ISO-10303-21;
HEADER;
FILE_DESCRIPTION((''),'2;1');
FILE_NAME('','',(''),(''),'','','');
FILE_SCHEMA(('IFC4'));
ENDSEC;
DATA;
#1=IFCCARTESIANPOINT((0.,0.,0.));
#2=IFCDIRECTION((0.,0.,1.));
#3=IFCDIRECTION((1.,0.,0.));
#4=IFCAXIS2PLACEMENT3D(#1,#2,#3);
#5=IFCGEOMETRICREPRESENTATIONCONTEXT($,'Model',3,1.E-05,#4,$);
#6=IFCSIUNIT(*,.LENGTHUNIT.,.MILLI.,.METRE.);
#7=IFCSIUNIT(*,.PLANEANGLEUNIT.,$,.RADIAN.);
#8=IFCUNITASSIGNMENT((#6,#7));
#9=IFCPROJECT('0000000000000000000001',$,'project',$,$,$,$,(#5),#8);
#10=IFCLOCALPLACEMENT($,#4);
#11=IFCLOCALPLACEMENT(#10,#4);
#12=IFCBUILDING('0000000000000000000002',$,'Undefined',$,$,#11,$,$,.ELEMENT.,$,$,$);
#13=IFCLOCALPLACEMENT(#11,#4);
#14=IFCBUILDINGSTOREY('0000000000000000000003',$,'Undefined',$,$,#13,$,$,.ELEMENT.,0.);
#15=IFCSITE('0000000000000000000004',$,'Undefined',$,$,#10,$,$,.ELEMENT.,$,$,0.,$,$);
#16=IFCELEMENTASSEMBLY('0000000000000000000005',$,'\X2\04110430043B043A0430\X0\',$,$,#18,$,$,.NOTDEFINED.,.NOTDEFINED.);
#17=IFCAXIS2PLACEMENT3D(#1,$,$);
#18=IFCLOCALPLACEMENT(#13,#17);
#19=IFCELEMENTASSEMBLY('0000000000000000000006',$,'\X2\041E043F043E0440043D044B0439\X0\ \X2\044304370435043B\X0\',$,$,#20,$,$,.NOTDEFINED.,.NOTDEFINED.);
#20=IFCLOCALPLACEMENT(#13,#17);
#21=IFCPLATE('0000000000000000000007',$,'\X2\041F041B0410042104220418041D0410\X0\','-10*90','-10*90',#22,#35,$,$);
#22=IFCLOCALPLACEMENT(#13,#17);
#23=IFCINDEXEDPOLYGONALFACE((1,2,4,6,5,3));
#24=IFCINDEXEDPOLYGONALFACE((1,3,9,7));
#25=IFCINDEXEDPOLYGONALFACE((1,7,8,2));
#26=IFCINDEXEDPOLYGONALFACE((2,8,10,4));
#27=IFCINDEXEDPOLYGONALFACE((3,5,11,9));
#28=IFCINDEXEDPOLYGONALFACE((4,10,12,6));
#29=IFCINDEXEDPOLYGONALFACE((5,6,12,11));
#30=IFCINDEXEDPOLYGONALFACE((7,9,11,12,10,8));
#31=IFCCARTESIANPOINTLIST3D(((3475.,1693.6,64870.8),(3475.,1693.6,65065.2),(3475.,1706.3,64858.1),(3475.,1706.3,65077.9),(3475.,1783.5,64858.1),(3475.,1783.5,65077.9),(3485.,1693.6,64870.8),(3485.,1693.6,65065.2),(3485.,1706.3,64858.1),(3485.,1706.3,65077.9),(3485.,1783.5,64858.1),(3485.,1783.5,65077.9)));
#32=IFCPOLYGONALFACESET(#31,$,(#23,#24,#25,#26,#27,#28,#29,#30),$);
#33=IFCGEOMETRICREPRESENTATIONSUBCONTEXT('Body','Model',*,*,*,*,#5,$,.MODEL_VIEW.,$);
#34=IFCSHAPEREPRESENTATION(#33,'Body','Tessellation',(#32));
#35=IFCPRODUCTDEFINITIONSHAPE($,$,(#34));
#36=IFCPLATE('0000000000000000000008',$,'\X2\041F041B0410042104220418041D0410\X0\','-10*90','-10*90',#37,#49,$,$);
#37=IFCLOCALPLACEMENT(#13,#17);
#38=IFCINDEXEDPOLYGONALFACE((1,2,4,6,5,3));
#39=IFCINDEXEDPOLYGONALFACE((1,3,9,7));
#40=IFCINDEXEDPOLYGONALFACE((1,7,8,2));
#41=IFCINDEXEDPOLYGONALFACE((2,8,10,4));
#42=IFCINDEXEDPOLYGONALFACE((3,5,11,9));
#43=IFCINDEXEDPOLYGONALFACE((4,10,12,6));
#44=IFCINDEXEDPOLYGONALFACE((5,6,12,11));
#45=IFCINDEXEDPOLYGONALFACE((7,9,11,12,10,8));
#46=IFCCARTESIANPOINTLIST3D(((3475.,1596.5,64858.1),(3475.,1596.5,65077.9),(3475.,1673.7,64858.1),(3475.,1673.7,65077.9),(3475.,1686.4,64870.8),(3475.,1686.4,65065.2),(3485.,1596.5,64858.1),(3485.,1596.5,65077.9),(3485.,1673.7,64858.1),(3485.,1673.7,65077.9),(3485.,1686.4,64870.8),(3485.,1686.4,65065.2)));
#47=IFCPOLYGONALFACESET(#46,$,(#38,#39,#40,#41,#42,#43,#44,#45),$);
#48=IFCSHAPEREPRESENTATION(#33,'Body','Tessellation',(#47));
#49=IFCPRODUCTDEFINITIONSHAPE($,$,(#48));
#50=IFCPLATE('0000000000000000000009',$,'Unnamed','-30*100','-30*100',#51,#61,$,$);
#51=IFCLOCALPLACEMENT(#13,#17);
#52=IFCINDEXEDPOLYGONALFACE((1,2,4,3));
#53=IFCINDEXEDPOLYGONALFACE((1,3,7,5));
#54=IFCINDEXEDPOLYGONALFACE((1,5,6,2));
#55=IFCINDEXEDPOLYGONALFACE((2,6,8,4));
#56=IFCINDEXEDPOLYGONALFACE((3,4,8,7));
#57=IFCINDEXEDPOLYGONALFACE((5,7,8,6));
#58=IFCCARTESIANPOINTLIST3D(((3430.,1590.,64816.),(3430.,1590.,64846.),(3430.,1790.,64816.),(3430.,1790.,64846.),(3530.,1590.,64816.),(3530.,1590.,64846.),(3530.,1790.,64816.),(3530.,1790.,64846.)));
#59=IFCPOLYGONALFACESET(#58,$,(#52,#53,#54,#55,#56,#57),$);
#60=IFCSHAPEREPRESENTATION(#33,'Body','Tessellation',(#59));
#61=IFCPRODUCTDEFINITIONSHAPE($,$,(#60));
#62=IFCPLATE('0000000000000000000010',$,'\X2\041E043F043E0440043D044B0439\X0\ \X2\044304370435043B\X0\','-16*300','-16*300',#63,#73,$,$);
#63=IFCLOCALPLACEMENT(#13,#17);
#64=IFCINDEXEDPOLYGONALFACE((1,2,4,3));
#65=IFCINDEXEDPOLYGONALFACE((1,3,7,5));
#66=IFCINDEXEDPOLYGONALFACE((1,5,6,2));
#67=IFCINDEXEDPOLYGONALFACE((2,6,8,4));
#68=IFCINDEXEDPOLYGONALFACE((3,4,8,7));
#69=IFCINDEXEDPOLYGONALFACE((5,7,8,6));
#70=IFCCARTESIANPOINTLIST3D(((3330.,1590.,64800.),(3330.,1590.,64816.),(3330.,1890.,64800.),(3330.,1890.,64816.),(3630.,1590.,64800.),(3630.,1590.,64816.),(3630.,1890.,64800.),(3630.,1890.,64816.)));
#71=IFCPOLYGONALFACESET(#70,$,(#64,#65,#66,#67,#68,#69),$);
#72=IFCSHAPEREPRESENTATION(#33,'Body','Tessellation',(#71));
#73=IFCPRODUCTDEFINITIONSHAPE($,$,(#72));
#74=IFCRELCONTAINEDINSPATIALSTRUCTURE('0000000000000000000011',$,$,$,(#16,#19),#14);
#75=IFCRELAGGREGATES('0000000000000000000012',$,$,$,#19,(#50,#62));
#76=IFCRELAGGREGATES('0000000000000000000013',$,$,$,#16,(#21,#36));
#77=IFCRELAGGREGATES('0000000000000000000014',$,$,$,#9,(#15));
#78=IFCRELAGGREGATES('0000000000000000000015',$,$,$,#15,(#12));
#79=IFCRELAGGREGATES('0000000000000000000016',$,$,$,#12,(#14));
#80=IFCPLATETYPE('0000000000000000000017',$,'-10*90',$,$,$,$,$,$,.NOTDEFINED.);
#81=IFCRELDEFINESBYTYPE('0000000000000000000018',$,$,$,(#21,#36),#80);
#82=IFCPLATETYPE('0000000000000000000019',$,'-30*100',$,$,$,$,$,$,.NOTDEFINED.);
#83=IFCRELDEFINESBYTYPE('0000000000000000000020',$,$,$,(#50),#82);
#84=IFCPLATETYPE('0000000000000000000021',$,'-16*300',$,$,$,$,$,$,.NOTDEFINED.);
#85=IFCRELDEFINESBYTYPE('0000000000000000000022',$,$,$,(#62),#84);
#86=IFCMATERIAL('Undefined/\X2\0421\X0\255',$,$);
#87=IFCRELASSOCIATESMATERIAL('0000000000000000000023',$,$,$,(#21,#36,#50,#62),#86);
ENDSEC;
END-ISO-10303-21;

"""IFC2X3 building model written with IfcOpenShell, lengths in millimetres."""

from ifc_helpers import new_model, si_unit, frame, origin_with_axes, place, context, subcontext, project, spatial, polyline, outline, extrude, material, type_object, element, aggregate, save


model = new_model("IFC2X3")

# Units and contexts
model_context = context("Model", 3, precision=1e-05, world=origin_with_axes())
body_context = subcontext(model_context, "Body", "Model", "MODEL_VIEW")
ifc_project = project(units=[si_unit("LENGTHUNIT", "METRE", prefix="MILLI"), si_unit("PLANEANGLEUNIT", "RADIAN")], contexts=[model_context])

# Site, building, storey
site_placement = place(None, origin_with_axes())
site = spatial("IfcSite", under=ifc_project, at=site_placement, Name="Undefined", CompositionType="ELEMENT", RefElevation=0.0)
building_placement = place(site_placement, origin_with_axes())
building = spatial("IfcBuilding", under=site, at=building_placement, Name="Undefined", CompositionType="ELEMENT")
storey_placement = place(building_placement, origin_with_axes())
storey = spatial("IfcBuildingStorey", under=building, at=storey_placement, Name="Undefined", CompositionType="ELEMENT", Elevation=0.0)

# Shared definitions
ifc_material_1 = material(Name="Undefined/С255")

# Element assembly
assembly_1_placement = place(storey_placement, origin_with_axes())
assembly_1 = element("IfcElementAssembly", 1, at=assembly_1_placement, inside=storey, Name="Балка", AssemblyPlace="NOTDEFINED", PredefinedType="NOTDEFINED")

# Element assembly
assembly_2_placement = place(storey_placement, origin_with_axes())
assembly_2 = element("IfcElementAssembly", 2, at=assembly_2_placement, inside=storey, Name="Опорный узел", AssemblyPlace="NOTDEFINED", PredefinedType="NOTDEFINED")

# Plates
plate_type_1 = type_object("IfcPlateType", Name="-10*90", PredefinedType="NOTDEFINED")
plate_1_placement = place(assembly_1_placement, frame((3480.0, 1693.6, 65077.9), z_axis=(-1.0, 0.0, 0.0), x_axis=(0.0, 1.0, 0.0)))
plate_1 = element("IfcPlate", 3, at=plate_1_placement, type_object=plate_type_1, material=ifc_material_1, Name="ПЛАСТИНА", Description="-10*90", ObjectType="-10*90", context=body_context, shape_type="SweptSolid", body=[
    extrude(outline(polyline([(0.0, 12.7), (12.7, 0.0), (89.9, 0.0), (89.9, 219.8), (12.7, 219.8), (0.0, 207.1), (0.0, 12.7)])), frame((0.0, 0.0, -5.0), z_axis=(0.0, 0.0, 1.0), x_axis=(1.0, 0.0, 0.0)), (0.0, 0.0, 1.0), 10.0),
])
plate_2_placement = place(assembly_1_placement, frame((3480.0, 1596.5, 65077.9), z_axis=(-1.0, 0.0, 0.0), x_axis=(0.0, 1.0, 0.0)))
plate_2 = element("IfcPlate", 4, at=plate_2_placement, type_object=plate_type_1, material=ifc_material_1, Name="ПЛАСТИНА", Description="-10*90", ObjectType="-10*90", context=body_context, shape_type="SweptSolid", body=[
    extrude(outline(polyline([(0.0, 0.0), (77.2, 0.0), (89.9, 12.7), (89.9, 207.1), (77.2, 219.8), (0.0, 219.8), (0.0, 0.0)])), frame((0.0, 0.0, -5.0), z_axis=(0.0, 0.0, 1.0), x_axis=(1.0, 0.0, 0.0)), (0.0, 0.0, 1.0), 10.0),
])
plate_type_2 = type_object("IfcPlateType", Name="-30*100", PredefinedType="NOTDEFINED")
plate_3_placement = place(assembly_2_placement, frame((3430.0, 1790.0, 64831.0), z_axis=(0.0, 0.0, 1.0), x_axis=(0.0, -1.0, 0.0)))
plate_3 = element("IfcPlate", 5, at=plate_3_placement, type_object=plate_type_2, material=ifc_material_1, Name="Unnamed", Description="-30*100", ObjectType="-30*100", context=body_context, shape_type="SweptSolid", body=[
    extrude(outline(polyline([(0.0, 0.0), (200.0, 0.0), (200.0, 100.0), (0.0, 100.0), (0.0, 0.0)])), frame((0.0, 0.0, -15.0), z_axis=(0.0, 0.0, 1.0), x_axis=(1.0, 0.0, 0.0)), (0.0, 0.0, 1.0), 30.0),
])
plate_type_3 = type_object("IfcPlateType", Name="-16*300", PredefinedType="NOTDEFINED")
plate_4_placement = place(assembly_2_placement, frame((3330.0, 1890.0, 64808.0), z_axis=(0.0, 0.0, 1.0), x_axis=(0.0, -1.0, 0.0)))
plate_4 = element("IfcPlate", 6, at=plate_4_placement, type_object=plate_type_3, material=ifc_material_1, Name="Опорный узел", Description="-16*300", ObjectType="-16*300", context=body_context, shape_type="SweptSolid", body=[
    extrude(outline(polyline([(0.0, 0.0), (300.0, 0.0), (300.0, 300.0), (0.0, 300.0), (0.0, 0.0)])), frame((0.0, 0.0, -8.0), z_axis=(0.0, 0.0, 1.0), x_axis=(1.0, 0.0, 0.0)), (0.0, 0.0, 1.0), 16.0),
])
aggregate(assembly_2, [plate_3, plate_4])

aggregate(assembly_1, [plate_1, plate_2])

save(model, "model.ifc")
